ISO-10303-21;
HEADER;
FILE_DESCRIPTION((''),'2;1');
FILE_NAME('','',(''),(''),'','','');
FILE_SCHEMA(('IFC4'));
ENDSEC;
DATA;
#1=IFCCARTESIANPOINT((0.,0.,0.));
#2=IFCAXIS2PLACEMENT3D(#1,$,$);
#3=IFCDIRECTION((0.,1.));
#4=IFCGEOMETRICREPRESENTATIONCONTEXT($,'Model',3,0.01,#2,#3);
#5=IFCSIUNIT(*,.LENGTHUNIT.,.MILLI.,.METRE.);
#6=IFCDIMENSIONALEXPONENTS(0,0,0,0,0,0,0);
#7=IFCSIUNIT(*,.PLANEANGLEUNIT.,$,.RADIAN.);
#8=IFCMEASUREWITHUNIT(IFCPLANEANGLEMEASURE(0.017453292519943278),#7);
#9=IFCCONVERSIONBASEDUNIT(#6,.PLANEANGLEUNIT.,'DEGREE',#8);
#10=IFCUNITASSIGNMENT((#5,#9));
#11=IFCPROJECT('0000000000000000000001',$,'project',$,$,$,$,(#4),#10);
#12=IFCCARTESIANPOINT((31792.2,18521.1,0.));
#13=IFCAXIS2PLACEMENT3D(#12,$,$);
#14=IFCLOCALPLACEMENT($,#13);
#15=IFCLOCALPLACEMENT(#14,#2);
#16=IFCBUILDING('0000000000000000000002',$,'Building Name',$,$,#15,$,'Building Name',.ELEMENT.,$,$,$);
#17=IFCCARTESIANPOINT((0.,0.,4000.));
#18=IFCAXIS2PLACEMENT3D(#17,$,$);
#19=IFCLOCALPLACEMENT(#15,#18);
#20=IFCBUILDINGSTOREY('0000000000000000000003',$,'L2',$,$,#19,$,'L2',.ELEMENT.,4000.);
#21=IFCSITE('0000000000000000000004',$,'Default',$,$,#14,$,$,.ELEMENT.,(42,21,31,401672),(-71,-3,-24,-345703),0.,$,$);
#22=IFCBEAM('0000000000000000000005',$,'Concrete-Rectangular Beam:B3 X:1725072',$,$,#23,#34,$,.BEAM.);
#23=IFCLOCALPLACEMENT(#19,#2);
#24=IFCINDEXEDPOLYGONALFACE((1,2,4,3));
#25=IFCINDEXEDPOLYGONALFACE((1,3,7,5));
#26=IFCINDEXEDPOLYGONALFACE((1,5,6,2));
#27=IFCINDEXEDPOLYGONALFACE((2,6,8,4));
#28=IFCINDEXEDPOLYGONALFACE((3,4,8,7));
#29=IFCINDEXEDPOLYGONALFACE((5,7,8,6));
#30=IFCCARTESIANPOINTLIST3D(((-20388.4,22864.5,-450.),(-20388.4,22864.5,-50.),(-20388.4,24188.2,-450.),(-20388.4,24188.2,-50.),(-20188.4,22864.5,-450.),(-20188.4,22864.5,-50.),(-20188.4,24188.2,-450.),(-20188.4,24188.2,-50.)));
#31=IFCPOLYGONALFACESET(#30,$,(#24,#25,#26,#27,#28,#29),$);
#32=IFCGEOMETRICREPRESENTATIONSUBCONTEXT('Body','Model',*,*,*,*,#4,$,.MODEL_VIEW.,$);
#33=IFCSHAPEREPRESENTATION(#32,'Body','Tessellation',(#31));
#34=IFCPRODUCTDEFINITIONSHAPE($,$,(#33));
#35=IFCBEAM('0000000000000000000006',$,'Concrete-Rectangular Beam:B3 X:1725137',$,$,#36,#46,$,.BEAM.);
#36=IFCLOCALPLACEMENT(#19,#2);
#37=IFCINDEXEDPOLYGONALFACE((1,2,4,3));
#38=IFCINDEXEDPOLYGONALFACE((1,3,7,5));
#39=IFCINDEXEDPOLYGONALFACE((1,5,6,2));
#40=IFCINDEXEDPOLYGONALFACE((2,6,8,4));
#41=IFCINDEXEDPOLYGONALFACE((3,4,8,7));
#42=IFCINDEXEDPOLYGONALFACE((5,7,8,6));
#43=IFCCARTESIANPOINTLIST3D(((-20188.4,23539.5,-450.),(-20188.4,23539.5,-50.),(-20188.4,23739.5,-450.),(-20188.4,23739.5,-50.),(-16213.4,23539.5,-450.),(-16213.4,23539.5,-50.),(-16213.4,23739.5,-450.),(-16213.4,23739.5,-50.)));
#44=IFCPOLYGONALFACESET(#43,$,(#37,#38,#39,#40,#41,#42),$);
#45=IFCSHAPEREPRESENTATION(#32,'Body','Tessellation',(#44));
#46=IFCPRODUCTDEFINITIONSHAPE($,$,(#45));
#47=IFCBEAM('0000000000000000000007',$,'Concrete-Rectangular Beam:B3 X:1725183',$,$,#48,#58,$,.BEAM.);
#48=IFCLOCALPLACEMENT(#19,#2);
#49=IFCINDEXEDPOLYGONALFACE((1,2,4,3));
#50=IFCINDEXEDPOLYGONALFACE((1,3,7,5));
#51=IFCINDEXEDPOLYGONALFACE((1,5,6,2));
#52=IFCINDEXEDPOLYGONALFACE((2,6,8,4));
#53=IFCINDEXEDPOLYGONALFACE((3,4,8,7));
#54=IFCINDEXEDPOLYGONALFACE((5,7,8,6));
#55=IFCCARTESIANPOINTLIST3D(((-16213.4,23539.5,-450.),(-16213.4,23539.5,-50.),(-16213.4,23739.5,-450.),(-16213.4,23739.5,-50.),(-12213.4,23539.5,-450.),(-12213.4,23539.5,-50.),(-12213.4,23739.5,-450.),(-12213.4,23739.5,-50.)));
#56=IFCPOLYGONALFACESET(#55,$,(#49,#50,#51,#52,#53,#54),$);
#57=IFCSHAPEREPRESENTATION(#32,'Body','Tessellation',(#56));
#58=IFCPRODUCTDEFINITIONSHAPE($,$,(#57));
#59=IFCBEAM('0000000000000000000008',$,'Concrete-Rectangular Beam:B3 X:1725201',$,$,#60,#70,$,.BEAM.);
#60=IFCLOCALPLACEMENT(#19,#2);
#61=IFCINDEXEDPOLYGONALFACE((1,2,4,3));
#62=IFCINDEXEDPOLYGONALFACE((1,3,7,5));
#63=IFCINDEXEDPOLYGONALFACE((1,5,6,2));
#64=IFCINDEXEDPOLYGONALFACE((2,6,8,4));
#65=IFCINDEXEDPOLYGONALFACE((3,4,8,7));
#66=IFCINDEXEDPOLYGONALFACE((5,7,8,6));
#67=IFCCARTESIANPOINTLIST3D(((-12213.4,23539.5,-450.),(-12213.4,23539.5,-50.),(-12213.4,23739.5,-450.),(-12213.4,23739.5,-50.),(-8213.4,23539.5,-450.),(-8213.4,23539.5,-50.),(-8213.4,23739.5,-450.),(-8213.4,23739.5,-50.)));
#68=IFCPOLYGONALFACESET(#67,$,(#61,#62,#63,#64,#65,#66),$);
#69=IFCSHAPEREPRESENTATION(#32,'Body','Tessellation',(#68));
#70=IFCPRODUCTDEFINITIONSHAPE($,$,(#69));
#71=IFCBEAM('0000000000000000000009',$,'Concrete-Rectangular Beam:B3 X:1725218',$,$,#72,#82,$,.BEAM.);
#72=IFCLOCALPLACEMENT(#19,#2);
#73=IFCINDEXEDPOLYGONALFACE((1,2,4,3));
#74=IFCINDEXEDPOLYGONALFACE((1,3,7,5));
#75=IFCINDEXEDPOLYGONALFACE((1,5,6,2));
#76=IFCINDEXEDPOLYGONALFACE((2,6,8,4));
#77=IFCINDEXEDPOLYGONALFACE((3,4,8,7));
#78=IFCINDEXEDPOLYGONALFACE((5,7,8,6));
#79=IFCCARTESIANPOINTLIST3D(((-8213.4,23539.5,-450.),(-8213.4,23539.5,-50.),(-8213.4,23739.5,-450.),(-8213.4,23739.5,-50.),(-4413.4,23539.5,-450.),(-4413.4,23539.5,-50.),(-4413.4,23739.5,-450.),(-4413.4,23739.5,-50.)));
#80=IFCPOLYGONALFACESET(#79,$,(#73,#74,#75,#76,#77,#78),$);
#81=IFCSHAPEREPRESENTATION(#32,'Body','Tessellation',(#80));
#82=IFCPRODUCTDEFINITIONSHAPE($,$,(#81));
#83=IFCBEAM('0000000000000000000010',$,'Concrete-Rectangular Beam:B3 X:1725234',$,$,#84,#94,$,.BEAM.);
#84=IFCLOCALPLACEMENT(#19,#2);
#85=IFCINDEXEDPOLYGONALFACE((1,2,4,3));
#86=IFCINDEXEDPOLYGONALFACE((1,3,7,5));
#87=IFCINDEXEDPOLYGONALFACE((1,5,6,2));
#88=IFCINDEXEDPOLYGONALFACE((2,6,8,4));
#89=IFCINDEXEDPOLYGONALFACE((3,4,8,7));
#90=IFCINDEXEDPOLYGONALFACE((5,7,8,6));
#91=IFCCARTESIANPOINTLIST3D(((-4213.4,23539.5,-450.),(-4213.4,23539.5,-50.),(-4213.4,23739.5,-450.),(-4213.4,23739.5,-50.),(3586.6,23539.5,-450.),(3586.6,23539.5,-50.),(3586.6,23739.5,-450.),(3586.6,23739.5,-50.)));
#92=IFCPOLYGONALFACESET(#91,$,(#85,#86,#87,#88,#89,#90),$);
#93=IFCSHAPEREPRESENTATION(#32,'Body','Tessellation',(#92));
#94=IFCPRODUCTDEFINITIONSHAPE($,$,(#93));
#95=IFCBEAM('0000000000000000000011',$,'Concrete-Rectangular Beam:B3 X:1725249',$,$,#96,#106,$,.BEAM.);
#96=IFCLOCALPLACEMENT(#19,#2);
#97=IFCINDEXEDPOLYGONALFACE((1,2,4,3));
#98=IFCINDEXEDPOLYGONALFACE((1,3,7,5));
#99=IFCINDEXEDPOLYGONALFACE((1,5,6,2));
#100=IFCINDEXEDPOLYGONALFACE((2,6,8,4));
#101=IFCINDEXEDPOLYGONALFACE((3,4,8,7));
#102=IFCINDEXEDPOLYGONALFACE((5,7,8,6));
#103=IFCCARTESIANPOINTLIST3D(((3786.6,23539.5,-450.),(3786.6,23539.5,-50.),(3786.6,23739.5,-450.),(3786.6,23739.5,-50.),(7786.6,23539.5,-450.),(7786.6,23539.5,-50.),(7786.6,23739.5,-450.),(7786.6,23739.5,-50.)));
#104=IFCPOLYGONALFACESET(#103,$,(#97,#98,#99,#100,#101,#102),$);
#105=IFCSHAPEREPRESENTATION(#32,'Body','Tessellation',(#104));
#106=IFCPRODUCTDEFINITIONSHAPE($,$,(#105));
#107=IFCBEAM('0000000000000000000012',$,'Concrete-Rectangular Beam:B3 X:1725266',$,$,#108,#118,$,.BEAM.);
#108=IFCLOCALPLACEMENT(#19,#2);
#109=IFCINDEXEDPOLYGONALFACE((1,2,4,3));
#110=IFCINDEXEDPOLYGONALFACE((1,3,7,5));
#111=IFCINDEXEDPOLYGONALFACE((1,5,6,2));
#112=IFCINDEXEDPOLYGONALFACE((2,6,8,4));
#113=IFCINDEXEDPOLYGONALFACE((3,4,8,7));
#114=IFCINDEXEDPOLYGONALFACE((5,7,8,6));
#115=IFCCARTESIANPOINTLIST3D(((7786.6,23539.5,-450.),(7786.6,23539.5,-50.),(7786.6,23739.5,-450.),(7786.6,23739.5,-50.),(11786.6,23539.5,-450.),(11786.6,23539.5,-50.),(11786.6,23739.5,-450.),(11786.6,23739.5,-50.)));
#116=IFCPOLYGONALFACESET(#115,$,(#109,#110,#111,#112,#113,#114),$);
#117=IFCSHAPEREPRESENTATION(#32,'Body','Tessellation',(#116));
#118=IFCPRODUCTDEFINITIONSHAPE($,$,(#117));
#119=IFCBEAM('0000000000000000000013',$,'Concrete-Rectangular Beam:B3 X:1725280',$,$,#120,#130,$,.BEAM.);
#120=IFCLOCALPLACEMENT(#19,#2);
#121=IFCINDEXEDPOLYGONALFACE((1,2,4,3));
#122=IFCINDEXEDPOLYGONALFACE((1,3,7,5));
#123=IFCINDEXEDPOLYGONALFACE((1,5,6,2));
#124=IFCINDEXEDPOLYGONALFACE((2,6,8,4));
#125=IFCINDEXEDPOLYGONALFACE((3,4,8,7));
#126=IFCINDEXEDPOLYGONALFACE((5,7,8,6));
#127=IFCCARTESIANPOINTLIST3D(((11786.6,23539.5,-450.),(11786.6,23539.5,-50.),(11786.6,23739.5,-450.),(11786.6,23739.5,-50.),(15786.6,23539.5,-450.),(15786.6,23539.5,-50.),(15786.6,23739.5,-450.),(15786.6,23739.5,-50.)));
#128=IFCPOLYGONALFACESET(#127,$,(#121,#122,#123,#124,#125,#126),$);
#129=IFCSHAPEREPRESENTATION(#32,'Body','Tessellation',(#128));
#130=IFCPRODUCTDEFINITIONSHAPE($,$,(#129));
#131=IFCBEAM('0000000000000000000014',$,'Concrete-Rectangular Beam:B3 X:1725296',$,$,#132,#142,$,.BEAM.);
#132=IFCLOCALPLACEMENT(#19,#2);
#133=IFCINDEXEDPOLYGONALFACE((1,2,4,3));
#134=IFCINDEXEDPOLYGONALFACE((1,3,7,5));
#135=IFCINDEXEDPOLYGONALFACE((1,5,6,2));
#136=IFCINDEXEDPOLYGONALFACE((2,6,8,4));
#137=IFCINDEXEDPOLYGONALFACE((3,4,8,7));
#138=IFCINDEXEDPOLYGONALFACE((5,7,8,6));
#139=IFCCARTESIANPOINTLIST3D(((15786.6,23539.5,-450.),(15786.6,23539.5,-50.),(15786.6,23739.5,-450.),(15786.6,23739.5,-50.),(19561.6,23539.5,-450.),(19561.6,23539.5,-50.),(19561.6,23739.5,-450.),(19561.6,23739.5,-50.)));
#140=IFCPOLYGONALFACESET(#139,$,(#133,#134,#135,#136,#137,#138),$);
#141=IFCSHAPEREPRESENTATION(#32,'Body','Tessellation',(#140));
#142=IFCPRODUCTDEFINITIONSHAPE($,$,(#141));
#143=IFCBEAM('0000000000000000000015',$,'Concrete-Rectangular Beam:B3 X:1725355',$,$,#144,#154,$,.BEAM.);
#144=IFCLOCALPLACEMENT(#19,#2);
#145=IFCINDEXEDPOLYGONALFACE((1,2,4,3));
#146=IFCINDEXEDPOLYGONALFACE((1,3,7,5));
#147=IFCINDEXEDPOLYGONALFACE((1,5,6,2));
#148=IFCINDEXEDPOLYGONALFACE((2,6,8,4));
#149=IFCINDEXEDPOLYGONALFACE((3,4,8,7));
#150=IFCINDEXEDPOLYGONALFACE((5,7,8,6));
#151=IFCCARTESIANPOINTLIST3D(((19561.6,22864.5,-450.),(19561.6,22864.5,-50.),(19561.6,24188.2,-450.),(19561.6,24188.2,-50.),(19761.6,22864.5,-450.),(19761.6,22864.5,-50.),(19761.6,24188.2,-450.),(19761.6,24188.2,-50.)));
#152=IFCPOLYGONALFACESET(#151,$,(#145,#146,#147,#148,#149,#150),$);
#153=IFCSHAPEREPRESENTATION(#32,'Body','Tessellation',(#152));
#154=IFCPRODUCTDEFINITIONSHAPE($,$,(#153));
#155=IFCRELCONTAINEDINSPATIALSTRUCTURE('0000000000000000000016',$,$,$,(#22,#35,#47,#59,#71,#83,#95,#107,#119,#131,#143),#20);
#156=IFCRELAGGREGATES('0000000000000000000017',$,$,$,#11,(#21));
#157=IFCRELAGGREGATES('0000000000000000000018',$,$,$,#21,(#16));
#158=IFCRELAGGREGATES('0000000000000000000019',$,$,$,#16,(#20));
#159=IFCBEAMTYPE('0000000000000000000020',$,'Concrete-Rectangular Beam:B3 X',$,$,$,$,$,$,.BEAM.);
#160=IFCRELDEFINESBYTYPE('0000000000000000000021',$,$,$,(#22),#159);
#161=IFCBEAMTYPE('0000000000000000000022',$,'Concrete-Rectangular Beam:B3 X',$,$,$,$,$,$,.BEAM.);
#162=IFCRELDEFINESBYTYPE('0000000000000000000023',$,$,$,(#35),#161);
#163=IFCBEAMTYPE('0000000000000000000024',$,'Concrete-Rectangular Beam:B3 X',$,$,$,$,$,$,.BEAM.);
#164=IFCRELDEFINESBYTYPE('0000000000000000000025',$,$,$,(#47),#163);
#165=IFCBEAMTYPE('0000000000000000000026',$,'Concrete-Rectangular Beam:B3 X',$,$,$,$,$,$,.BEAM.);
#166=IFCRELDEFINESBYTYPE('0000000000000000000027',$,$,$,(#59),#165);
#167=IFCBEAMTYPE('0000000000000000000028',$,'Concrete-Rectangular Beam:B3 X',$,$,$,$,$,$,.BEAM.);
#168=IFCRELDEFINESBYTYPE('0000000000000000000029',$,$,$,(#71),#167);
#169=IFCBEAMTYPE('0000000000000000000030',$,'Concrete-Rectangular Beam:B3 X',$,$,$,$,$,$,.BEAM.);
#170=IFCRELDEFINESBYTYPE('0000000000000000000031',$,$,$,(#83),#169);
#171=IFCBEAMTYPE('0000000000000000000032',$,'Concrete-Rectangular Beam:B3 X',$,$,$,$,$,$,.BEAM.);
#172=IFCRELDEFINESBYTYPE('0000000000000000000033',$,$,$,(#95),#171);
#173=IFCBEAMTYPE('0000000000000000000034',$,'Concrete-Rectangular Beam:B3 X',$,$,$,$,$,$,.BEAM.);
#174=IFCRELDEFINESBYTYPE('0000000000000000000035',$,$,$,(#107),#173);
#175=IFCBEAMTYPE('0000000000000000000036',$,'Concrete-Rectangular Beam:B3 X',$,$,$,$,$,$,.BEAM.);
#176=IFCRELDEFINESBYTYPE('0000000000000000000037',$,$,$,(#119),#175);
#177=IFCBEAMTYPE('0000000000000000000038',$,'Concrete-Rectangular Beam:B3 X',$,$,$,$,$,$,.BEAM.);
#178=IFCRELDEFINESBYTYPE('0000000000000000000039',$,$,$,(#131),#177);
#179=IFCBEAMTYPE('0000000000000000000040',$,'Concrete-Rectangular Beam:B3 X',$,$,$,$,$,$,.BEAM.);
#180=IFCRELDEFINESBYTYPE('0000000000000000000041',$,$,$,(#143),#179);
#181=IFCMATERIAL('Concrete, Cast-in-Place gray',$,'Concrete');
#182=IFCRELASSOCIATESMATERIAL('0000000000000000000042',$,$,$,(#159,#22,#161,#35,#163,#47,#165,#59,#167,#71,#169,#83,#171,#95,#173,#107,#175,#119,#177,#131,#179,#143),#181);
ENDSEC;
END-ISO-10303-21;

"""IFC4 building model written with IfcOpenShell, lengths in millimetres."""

from ifc_helpers import new_model, entity, si_unit, converted_unit, direction, frame, origin, place, context, subcontext, project, spatial, indexed_curve, outline, extrude, source, transform, mapped, material, type_object, type_shapes, element, save


model = new_model("IFC4")

# Units and contexts
model_context = context("Model", 3, precision=0.01, world=origin(), true_north=direction((0.0, 1.0)))
body_context = subcontext(model_context, "Body", "Model", "MODEL_VIEW")
ifc_project = project(units=[si_unit("LENGTHUNIT", "METRE", prefix="MILLI"), converted_unit("PLANEANGLEUNIT", "DEGREE", entity("IfcPlaneAngleMeasure", 0.017453292519943278), si_unit("PLANEANGLEUNIT", "RADIAN"), dimensions=[0, 0, 0, 0, 0, 0, 0])], contexts=[model_context])

# Site, building, storey
site_placement = place(None, frame((31792.2, 18521.1, 0.0)))
site = spatial("IfcSite", under=ifc_project, at=site_placement, Name="Default", CompositionType="ELEMENT", RefLatitude=(42, 21, 31, 401672), RefLongitude=(-71, -3, -24, -345703), RefElevation=0.0)
building_placement = place(site_placement, origin())
building = spatial("IfcBuilding", under=site, at=building_placement, Name="Building Name", LongName="Building Name", CompositionType="ELEMENT")
storey_placement = place(building_placement, frame((0.0, 0.0, 4000.0)))
storey = spatial("IfcBuildingStorey", under=building, at=storey_placement, Name="L2", LongName="L2", CompositionType="ELEMENT", Elevation=4000.0)

# Beams
ifc_material = material(Name="Concrete, Cast-in-Place gray", Category="Concrete")
beam_type_1 = type_object("IfcBeamType", Name="Concrete-Rectangular Beam:B3 X", PredefinedType="BEAM", material=ifc_material)
shared_shape_1 = source(origin(), body_context, "Body", "SweptSolid", [
    extrude(outline(indexed_curve([(-100.0, -200.0), (100.0, -200.0), (100.0, 200.0), (-100.0, 200.0), (-100.0, -200.0)], self_intersect=False)), frame((-20288.4, 24188.2, 3750.0), z_axis=(0.0, -1.0, 0.0), x_axis=(-1.0, 0.0, 0.0)), (0.0, 0.0, 1.0), 1323.7),
])
type_shapes(beam_type_1, [shared_shape_1])
beam_1_placement = place(storey_placement, frame((0.0, 0.0, -4000.0)))
element("IfcBeam", 1, at=beam_1_placement, inside=storey, type_object=beam_type_1, material=ifc_material, Name="Concrete-Rectangular Beam:B3 X:1725072", PredefinedType="BEAM", context=body_context, shape_type="MappedRepresentation", body=[
    mapped(shared_shape_1, transform((0.0, 0.0, 0.0), scale=1.0)),
])
beam_type_2 = type_object("IfcBeamType", Name="Concrete-Rectangular Beam:B3 X", PredefinedType="BEAM", material=ifc_material)
shared_shape_2 = source(origin(), body_context, "Body", "SweptSolid", [
    extrude(outline(indexed_curve([(-200.0, -100.0), (200.0, -100.0), (200.0, 100.0), (-200.0, 100.0), (-200.0, -100.0)], self_intersect=False)), frame((-20188.4, 23639.5, 3750.0), z_axis=(1.0, 0.0, 0.0), x_axis=(0.0, 0.0, -1.0)), (0.0, 0.0, 1.0), 3975.0),
])
type_shapes(beam_type_2, [shared_shape_2])
beam_2_placement = place(storey_placement, frame((0.0, 0.0, -4000.0)))
element("IfcBeam", 2, at=beam_2_placement, inside=storey, type_object=beam_type_2, material=ifc_material, Name="Concrete-Rectangular Beam:B3 X:1725137", PredefinedType="BEAM", context=body_context, shape_type="MappedRepresentation", body=[
    mapped(shared_shape_2, transform((0.0, 0.0, 0.0), scale=1.0)),
])
beam_type_3 = type_object("IfcBeamType", Name="Concrete-Rectangular Beam:B3 X", PredefinedType="BEAM", material=ifc_material)
shared_shape_3 = source(origin(), body_context, "Body", "SweptSolid", [
    extrude(outline(indexed_curve([(-200.0, -100.0), (200.0, -100.0), (200.0, 100.0), (-200.0, 100.0), (-200.0, -100.0)], self_intersect=False)), frame((-16213.4, 23639.5, 3750.0), z_axis=(1.0, 0.0, 0.0), x_axis=(0.0, 0.0, -1.0)), (0.0, 0.0, 1.0), 4000.0),
])
type_shapes(beam_type_3, [shared_shape_3])
beam_3_placement = place(storey_placement, frame((0.0, 0.0, -4000.0)))
element("IfcBeam", 3, at=beam_3_placement, inside=storey, type_object=beam_type_3, material=ifc_material, Name="Concrete-Rectangular Beam:B3 X:1725183", PredefinedType="BEAM", context=body_context, shape_type="MappedRepresentation", body=[
    mapped(shared_shape_3, transform((0.0, 0.0, 0.0), scale=1.0)),
])
beam_type_4 = type_object("IfcBeamType", Name="Concrete-Rectangular Beam:B3 X", PredefinedType="BEAM", material=ifc_material)
shared_shape_4 = source(origin(), body_context, "Body", "SweptSolid", [
    extrude(outline(indexed_curve([(-200.0, -100.0), (200.0, -100.0), (200.0, 100.0), (-200.0, 100.0), (-200.0, -100.0)], self_intersect=False)), frame((-12213.4, 23639.5, 3750.0), z_axis=(1.0, 0.0, 0.0), x_axis=(0.0, 0.0, -1.0)), (0.0, 0.0, 1.0), 4000.0),
])
type_shapes(beam_type_4, [shared_shape_4])
beam_4_placement = place(storey_placement, frame((0.0, 0.0, -4000.0)))
element("IfcBeam", 4, at=beam_4_placement, inside=storey, type_object=beam_type_4, material=ifc_material, Name="Concrete-Rectangular Beam:B3 X:1725201", PredefinedType="BEAM", context=body_context, shape_type="MappedRepresentation", body=[
    mapped(shared_shape_4, transform((0.0, 0.0, 0.0), scale=1.0)),
])
beam_type_5 = type_object("IfcBeamType", Name="Concrete-Rectangular Beam:B3 X", PredefinedType="BEAM", material=ifc_material)
shared_shape_5 = source(origin(), body_context, "Body", "SweptSolid", [
    extrude(outline(indexed_curve([(-200.0, -100.0), (200.0, -100.0), (200.0, 100.0), (-200.0, 100.0), (-200.0, -100.0)], self_intersect=False)), frame((-8213.4, 23639.5, 3750.0), z_axis=(1.0, 0.0, 0.0), x_axis=(0.0, 0.0, -1.0)), (0.0, 0.0, 1.0), 3800.0),
])
type_shapes(beam_type_5, [shared_shape_5])
beam_5_placement = place(storey_placement, frame((0.0, 0.0, -4000.0)))
element("IfcBeam", 5, at=beam_5_placement, inside=storey, type_object=beam_type_5, material=ifc_material, Name="Concrete-Rectangular Beam:B3 X:1725218", PredefinedType="BEAM", context=body_context, shape_type="MappedRepresentation", body=[
    mapped(shared_shape_5, transform((0.0, 0.0, 0.0), scale=1.0)),
])
beam_type_6 = type_object("IfcBeamType", Name="Concrete-Rectangular Beam:B3 X", PredefinedType="BEAM", material=ifc_material)
shared_shape_6 = source(origin(), body_context, "Body", "SweptSolid", [
    extrude(outline(indexed_curve([(-200.0, -100.0), (200.0, -100.0), (200.0, 100.0), (-200.0, 100.0), (-200.0, -100.0)], self_intersect=False)), frame((-4213.4, 23639.5, 3750.0), z_axis=(1.0, 0.0, 0.0), x_axis=(0.0, 0.0, -1.0)), (0.0, 0.0, 1.0), 7800.0),
])
type_shapes(beam_type_6, [shared_shape_6])
beam_6_placement = place(storey_placement, frame((0.0, 0.0, -4000.0)))
element("IfcBeam", 6, at=beam_6_placement, inside=storey, type_object=beam_type_6, material=ifc_material, Name="Concrete-Rectangular Beam:B3 X:1725234", PredefinedType="BEAM", context=body_context, shape_type="MappedRepresentation", body=[
    mapped(shared_shape_6, transform((0.0, 0.0, 0.0), scale=1.0)),
])
beam_type_7 = type_object("IfcBeamType", Name="Concrete-Rectangular Beam:B3 X", PredefinedType="BEAM", material=ifc_material)
shared_shape_7 = source(origin(), body_context, "Body", "SweptSolid", [
    extrude(outline(indexed_curve([(-200.0, -100.0), (200.0, -100.0), (200.0, 100.0), (-200.0, 100.0), (-200.0, -100.0)], self_intersect=False)), frame((3786.6, 23639.5, 3750.0), z_axis=(1.0, 0.0, 0.0), x_axis=(0.0, 0.0, -1.0)), (0.0, 0.0, 1.0), 4000.0),
])
type_shapes(beam_type_7, [shared_shape_7])
beam_7_placement = place(storey_placement, frame((0.0, 0.0, -4000.0)))
element("IfcBeam", 7, at=beam_7_placement, inside=storey, type_object=beam_type_7, material=ifc_material, Name="Concrete-Rectangular Beam:B3 X:1725249", PredefinedType="BEAM", context=body_context, shape_type="MappedRepresentation", body=[
    mapped(shared_shape_7, transform((0.0, 0.0, 0.0), scale=1.0)),
])
beam_type_8 = type_object("IfcBeamType", Name="Concrete-Rectangular Beam:B3 X", PredefinedType="BEAM", material=ifc_material)
shared_shape_8 = source(origin(), body_context, "Body", "SweptSolid", [
    extrude(outline(indexed_curve([(-200.0, -100.0), (200.0, -100.0), (200.0, 100.0), (-200.0, 100.0), (-200.0, -100.0)], self_intersect=False)), frame((7786.6, 23639.5, 3750.0), z_axis=(1.0, 0.0, 0.0), x_axis=(0.0, 0.0, -1.0)), (0.0, 0.0, 1.0), 4000.0),
])
type_shapes(beam_type_8, [shared_shape_8])
beam_8_placement = place(storey_placement, frame((0.0, 0.0, -4000.0)))
element("IfcBeam", 8, at=beam_8_placement, inside=storey, type_object=beam_type_8, material=ifc_material, Name="Concrete-Rectangular Beam:B3 X:1725266", PredefinedType="BEAM", context=body_context, shape_type="MappedRepresentation", body=[
    mapped(shared_shape_8, transform((0.0, 0.0, 0.0), scale=1.0)),
])
beam_type_9 = type_object("IfcBeamType", Name="Concrete-Rectangular Beam:B3 X", PredefinedType="BEAM", material=ifc_material)
shared_shape_9 = source(origin(), body_context, "Body", "SweptSolid", [
    extrude(outline(indexed_curve([(-200.0, -100.0), (200.0, -100.0), (200.0, 100.0), (-200.0, 100.0), (-200.0, -100.0)], self_intersect=False)), frame((11786.6, 23639.5, 3750.0), z_axis=(1.0, 0.0, 0.0), x_axis=(0.0, 0.0, -1.0)), (0.0, 0.0, 1.0), 4000.0),
])
type_shapes(beam_type_9, [shared_shape_9])
beam_9_placement = place(storey_placement, frame((0.0, 0.0, -4000.0)))
element("IfcBeam", 9, at=beam_9_placement, inside=storey, type_object=beam_type_9, material=ifc_material, Name="Concrete-Rectangular Beam:B3 X:1725280", PredefinedType="BEAM", context=body_context, shape_type="MappedRepresentation", body=[
    mapped(shared_shape_9, transform((0.0, 0.0, 0.0), scale=1.0)),
])
beam_type_10 = type_object("IfcBeamType", Name="Concrete-Rectangular Beam:B3 X", PredefinedType="BEAM", material=ifc_material)
shared_shape_10 = source(origin(), body_context, "Body", "SweptSolid", [
    extrude(outline(indexed_curve([(-200.0, -100.0), (200.0, -100.0), (200.0, 100.0), (-200.0, 100.0), (-200.0, -100.0)], self_intersect=False)), frame((15786.6, 23639.5, 3750.0), z_axis=(1.0, 0.0, 0.0), x_axis=(0.0, 0.0, -1.0)), (0.0, 0.0, 1.0), 3775.0),
])
type_shapes(beam_type_10, [shared_shape_10])
beam_10_placement = place(storey_placement, frame((0.0, 0.0, -4000.0)))
element("IfcBeam", 10, at=beam_10_placement, inside=storey, type_object=beam_type_10, material=ifc_material, Name="Concrete-Rectangular Beam:B3 X:1725296", PredefinedType="BEAM", context=body_context, shape_type="MappedRepresentation", body=[
    mapped(shared_shape_10, transform((0.0, 0.0, 0.0), scale=1.0)),
])
beam_type_11 = type_object("IfcBeamType", Name="Concrete-Rectangular Beam:B3 X", PredefinedType="BEAM", material=ifc_material)
shared_shape_11 = source(origin(), body_context, "Body", "SweptSolid", [
    extrude(outline(indexed_curve([(-100.0, -200.0), (100.0, -200.0), (100.0, 200.0), (-100.0, 200.0), (-100.0, -200.0)], self_intersect=False)), frame((19661.6, 24188.2, 3750.0), z_axis=(0.0, -1.0, 0.0), x_axis=(-1.0, 0.0, 0.0)), (0.0, 0.0, 1.0), 1323.7),
])
type_shapes(beam_type_11, [shared_shape_11])
beam_11_placement = place(storey_placement, frame((0.0, 0.0, -4000.0)))
element("IfcBeam", 11, at=beam_11_placement, inside=storey, type_object=beam_type_11, material=ifc_material, Name="Concrete-Rectangular Beam:B3 X:1725355", PredefinedType="BEAM", context=body_context, shape_type="MappedRepresentation", body=[
    mapped(shared_shape_11, transform((0.0, 0.0, 0.0), scale=1.0)),
])

save(model, "model.ifc")
